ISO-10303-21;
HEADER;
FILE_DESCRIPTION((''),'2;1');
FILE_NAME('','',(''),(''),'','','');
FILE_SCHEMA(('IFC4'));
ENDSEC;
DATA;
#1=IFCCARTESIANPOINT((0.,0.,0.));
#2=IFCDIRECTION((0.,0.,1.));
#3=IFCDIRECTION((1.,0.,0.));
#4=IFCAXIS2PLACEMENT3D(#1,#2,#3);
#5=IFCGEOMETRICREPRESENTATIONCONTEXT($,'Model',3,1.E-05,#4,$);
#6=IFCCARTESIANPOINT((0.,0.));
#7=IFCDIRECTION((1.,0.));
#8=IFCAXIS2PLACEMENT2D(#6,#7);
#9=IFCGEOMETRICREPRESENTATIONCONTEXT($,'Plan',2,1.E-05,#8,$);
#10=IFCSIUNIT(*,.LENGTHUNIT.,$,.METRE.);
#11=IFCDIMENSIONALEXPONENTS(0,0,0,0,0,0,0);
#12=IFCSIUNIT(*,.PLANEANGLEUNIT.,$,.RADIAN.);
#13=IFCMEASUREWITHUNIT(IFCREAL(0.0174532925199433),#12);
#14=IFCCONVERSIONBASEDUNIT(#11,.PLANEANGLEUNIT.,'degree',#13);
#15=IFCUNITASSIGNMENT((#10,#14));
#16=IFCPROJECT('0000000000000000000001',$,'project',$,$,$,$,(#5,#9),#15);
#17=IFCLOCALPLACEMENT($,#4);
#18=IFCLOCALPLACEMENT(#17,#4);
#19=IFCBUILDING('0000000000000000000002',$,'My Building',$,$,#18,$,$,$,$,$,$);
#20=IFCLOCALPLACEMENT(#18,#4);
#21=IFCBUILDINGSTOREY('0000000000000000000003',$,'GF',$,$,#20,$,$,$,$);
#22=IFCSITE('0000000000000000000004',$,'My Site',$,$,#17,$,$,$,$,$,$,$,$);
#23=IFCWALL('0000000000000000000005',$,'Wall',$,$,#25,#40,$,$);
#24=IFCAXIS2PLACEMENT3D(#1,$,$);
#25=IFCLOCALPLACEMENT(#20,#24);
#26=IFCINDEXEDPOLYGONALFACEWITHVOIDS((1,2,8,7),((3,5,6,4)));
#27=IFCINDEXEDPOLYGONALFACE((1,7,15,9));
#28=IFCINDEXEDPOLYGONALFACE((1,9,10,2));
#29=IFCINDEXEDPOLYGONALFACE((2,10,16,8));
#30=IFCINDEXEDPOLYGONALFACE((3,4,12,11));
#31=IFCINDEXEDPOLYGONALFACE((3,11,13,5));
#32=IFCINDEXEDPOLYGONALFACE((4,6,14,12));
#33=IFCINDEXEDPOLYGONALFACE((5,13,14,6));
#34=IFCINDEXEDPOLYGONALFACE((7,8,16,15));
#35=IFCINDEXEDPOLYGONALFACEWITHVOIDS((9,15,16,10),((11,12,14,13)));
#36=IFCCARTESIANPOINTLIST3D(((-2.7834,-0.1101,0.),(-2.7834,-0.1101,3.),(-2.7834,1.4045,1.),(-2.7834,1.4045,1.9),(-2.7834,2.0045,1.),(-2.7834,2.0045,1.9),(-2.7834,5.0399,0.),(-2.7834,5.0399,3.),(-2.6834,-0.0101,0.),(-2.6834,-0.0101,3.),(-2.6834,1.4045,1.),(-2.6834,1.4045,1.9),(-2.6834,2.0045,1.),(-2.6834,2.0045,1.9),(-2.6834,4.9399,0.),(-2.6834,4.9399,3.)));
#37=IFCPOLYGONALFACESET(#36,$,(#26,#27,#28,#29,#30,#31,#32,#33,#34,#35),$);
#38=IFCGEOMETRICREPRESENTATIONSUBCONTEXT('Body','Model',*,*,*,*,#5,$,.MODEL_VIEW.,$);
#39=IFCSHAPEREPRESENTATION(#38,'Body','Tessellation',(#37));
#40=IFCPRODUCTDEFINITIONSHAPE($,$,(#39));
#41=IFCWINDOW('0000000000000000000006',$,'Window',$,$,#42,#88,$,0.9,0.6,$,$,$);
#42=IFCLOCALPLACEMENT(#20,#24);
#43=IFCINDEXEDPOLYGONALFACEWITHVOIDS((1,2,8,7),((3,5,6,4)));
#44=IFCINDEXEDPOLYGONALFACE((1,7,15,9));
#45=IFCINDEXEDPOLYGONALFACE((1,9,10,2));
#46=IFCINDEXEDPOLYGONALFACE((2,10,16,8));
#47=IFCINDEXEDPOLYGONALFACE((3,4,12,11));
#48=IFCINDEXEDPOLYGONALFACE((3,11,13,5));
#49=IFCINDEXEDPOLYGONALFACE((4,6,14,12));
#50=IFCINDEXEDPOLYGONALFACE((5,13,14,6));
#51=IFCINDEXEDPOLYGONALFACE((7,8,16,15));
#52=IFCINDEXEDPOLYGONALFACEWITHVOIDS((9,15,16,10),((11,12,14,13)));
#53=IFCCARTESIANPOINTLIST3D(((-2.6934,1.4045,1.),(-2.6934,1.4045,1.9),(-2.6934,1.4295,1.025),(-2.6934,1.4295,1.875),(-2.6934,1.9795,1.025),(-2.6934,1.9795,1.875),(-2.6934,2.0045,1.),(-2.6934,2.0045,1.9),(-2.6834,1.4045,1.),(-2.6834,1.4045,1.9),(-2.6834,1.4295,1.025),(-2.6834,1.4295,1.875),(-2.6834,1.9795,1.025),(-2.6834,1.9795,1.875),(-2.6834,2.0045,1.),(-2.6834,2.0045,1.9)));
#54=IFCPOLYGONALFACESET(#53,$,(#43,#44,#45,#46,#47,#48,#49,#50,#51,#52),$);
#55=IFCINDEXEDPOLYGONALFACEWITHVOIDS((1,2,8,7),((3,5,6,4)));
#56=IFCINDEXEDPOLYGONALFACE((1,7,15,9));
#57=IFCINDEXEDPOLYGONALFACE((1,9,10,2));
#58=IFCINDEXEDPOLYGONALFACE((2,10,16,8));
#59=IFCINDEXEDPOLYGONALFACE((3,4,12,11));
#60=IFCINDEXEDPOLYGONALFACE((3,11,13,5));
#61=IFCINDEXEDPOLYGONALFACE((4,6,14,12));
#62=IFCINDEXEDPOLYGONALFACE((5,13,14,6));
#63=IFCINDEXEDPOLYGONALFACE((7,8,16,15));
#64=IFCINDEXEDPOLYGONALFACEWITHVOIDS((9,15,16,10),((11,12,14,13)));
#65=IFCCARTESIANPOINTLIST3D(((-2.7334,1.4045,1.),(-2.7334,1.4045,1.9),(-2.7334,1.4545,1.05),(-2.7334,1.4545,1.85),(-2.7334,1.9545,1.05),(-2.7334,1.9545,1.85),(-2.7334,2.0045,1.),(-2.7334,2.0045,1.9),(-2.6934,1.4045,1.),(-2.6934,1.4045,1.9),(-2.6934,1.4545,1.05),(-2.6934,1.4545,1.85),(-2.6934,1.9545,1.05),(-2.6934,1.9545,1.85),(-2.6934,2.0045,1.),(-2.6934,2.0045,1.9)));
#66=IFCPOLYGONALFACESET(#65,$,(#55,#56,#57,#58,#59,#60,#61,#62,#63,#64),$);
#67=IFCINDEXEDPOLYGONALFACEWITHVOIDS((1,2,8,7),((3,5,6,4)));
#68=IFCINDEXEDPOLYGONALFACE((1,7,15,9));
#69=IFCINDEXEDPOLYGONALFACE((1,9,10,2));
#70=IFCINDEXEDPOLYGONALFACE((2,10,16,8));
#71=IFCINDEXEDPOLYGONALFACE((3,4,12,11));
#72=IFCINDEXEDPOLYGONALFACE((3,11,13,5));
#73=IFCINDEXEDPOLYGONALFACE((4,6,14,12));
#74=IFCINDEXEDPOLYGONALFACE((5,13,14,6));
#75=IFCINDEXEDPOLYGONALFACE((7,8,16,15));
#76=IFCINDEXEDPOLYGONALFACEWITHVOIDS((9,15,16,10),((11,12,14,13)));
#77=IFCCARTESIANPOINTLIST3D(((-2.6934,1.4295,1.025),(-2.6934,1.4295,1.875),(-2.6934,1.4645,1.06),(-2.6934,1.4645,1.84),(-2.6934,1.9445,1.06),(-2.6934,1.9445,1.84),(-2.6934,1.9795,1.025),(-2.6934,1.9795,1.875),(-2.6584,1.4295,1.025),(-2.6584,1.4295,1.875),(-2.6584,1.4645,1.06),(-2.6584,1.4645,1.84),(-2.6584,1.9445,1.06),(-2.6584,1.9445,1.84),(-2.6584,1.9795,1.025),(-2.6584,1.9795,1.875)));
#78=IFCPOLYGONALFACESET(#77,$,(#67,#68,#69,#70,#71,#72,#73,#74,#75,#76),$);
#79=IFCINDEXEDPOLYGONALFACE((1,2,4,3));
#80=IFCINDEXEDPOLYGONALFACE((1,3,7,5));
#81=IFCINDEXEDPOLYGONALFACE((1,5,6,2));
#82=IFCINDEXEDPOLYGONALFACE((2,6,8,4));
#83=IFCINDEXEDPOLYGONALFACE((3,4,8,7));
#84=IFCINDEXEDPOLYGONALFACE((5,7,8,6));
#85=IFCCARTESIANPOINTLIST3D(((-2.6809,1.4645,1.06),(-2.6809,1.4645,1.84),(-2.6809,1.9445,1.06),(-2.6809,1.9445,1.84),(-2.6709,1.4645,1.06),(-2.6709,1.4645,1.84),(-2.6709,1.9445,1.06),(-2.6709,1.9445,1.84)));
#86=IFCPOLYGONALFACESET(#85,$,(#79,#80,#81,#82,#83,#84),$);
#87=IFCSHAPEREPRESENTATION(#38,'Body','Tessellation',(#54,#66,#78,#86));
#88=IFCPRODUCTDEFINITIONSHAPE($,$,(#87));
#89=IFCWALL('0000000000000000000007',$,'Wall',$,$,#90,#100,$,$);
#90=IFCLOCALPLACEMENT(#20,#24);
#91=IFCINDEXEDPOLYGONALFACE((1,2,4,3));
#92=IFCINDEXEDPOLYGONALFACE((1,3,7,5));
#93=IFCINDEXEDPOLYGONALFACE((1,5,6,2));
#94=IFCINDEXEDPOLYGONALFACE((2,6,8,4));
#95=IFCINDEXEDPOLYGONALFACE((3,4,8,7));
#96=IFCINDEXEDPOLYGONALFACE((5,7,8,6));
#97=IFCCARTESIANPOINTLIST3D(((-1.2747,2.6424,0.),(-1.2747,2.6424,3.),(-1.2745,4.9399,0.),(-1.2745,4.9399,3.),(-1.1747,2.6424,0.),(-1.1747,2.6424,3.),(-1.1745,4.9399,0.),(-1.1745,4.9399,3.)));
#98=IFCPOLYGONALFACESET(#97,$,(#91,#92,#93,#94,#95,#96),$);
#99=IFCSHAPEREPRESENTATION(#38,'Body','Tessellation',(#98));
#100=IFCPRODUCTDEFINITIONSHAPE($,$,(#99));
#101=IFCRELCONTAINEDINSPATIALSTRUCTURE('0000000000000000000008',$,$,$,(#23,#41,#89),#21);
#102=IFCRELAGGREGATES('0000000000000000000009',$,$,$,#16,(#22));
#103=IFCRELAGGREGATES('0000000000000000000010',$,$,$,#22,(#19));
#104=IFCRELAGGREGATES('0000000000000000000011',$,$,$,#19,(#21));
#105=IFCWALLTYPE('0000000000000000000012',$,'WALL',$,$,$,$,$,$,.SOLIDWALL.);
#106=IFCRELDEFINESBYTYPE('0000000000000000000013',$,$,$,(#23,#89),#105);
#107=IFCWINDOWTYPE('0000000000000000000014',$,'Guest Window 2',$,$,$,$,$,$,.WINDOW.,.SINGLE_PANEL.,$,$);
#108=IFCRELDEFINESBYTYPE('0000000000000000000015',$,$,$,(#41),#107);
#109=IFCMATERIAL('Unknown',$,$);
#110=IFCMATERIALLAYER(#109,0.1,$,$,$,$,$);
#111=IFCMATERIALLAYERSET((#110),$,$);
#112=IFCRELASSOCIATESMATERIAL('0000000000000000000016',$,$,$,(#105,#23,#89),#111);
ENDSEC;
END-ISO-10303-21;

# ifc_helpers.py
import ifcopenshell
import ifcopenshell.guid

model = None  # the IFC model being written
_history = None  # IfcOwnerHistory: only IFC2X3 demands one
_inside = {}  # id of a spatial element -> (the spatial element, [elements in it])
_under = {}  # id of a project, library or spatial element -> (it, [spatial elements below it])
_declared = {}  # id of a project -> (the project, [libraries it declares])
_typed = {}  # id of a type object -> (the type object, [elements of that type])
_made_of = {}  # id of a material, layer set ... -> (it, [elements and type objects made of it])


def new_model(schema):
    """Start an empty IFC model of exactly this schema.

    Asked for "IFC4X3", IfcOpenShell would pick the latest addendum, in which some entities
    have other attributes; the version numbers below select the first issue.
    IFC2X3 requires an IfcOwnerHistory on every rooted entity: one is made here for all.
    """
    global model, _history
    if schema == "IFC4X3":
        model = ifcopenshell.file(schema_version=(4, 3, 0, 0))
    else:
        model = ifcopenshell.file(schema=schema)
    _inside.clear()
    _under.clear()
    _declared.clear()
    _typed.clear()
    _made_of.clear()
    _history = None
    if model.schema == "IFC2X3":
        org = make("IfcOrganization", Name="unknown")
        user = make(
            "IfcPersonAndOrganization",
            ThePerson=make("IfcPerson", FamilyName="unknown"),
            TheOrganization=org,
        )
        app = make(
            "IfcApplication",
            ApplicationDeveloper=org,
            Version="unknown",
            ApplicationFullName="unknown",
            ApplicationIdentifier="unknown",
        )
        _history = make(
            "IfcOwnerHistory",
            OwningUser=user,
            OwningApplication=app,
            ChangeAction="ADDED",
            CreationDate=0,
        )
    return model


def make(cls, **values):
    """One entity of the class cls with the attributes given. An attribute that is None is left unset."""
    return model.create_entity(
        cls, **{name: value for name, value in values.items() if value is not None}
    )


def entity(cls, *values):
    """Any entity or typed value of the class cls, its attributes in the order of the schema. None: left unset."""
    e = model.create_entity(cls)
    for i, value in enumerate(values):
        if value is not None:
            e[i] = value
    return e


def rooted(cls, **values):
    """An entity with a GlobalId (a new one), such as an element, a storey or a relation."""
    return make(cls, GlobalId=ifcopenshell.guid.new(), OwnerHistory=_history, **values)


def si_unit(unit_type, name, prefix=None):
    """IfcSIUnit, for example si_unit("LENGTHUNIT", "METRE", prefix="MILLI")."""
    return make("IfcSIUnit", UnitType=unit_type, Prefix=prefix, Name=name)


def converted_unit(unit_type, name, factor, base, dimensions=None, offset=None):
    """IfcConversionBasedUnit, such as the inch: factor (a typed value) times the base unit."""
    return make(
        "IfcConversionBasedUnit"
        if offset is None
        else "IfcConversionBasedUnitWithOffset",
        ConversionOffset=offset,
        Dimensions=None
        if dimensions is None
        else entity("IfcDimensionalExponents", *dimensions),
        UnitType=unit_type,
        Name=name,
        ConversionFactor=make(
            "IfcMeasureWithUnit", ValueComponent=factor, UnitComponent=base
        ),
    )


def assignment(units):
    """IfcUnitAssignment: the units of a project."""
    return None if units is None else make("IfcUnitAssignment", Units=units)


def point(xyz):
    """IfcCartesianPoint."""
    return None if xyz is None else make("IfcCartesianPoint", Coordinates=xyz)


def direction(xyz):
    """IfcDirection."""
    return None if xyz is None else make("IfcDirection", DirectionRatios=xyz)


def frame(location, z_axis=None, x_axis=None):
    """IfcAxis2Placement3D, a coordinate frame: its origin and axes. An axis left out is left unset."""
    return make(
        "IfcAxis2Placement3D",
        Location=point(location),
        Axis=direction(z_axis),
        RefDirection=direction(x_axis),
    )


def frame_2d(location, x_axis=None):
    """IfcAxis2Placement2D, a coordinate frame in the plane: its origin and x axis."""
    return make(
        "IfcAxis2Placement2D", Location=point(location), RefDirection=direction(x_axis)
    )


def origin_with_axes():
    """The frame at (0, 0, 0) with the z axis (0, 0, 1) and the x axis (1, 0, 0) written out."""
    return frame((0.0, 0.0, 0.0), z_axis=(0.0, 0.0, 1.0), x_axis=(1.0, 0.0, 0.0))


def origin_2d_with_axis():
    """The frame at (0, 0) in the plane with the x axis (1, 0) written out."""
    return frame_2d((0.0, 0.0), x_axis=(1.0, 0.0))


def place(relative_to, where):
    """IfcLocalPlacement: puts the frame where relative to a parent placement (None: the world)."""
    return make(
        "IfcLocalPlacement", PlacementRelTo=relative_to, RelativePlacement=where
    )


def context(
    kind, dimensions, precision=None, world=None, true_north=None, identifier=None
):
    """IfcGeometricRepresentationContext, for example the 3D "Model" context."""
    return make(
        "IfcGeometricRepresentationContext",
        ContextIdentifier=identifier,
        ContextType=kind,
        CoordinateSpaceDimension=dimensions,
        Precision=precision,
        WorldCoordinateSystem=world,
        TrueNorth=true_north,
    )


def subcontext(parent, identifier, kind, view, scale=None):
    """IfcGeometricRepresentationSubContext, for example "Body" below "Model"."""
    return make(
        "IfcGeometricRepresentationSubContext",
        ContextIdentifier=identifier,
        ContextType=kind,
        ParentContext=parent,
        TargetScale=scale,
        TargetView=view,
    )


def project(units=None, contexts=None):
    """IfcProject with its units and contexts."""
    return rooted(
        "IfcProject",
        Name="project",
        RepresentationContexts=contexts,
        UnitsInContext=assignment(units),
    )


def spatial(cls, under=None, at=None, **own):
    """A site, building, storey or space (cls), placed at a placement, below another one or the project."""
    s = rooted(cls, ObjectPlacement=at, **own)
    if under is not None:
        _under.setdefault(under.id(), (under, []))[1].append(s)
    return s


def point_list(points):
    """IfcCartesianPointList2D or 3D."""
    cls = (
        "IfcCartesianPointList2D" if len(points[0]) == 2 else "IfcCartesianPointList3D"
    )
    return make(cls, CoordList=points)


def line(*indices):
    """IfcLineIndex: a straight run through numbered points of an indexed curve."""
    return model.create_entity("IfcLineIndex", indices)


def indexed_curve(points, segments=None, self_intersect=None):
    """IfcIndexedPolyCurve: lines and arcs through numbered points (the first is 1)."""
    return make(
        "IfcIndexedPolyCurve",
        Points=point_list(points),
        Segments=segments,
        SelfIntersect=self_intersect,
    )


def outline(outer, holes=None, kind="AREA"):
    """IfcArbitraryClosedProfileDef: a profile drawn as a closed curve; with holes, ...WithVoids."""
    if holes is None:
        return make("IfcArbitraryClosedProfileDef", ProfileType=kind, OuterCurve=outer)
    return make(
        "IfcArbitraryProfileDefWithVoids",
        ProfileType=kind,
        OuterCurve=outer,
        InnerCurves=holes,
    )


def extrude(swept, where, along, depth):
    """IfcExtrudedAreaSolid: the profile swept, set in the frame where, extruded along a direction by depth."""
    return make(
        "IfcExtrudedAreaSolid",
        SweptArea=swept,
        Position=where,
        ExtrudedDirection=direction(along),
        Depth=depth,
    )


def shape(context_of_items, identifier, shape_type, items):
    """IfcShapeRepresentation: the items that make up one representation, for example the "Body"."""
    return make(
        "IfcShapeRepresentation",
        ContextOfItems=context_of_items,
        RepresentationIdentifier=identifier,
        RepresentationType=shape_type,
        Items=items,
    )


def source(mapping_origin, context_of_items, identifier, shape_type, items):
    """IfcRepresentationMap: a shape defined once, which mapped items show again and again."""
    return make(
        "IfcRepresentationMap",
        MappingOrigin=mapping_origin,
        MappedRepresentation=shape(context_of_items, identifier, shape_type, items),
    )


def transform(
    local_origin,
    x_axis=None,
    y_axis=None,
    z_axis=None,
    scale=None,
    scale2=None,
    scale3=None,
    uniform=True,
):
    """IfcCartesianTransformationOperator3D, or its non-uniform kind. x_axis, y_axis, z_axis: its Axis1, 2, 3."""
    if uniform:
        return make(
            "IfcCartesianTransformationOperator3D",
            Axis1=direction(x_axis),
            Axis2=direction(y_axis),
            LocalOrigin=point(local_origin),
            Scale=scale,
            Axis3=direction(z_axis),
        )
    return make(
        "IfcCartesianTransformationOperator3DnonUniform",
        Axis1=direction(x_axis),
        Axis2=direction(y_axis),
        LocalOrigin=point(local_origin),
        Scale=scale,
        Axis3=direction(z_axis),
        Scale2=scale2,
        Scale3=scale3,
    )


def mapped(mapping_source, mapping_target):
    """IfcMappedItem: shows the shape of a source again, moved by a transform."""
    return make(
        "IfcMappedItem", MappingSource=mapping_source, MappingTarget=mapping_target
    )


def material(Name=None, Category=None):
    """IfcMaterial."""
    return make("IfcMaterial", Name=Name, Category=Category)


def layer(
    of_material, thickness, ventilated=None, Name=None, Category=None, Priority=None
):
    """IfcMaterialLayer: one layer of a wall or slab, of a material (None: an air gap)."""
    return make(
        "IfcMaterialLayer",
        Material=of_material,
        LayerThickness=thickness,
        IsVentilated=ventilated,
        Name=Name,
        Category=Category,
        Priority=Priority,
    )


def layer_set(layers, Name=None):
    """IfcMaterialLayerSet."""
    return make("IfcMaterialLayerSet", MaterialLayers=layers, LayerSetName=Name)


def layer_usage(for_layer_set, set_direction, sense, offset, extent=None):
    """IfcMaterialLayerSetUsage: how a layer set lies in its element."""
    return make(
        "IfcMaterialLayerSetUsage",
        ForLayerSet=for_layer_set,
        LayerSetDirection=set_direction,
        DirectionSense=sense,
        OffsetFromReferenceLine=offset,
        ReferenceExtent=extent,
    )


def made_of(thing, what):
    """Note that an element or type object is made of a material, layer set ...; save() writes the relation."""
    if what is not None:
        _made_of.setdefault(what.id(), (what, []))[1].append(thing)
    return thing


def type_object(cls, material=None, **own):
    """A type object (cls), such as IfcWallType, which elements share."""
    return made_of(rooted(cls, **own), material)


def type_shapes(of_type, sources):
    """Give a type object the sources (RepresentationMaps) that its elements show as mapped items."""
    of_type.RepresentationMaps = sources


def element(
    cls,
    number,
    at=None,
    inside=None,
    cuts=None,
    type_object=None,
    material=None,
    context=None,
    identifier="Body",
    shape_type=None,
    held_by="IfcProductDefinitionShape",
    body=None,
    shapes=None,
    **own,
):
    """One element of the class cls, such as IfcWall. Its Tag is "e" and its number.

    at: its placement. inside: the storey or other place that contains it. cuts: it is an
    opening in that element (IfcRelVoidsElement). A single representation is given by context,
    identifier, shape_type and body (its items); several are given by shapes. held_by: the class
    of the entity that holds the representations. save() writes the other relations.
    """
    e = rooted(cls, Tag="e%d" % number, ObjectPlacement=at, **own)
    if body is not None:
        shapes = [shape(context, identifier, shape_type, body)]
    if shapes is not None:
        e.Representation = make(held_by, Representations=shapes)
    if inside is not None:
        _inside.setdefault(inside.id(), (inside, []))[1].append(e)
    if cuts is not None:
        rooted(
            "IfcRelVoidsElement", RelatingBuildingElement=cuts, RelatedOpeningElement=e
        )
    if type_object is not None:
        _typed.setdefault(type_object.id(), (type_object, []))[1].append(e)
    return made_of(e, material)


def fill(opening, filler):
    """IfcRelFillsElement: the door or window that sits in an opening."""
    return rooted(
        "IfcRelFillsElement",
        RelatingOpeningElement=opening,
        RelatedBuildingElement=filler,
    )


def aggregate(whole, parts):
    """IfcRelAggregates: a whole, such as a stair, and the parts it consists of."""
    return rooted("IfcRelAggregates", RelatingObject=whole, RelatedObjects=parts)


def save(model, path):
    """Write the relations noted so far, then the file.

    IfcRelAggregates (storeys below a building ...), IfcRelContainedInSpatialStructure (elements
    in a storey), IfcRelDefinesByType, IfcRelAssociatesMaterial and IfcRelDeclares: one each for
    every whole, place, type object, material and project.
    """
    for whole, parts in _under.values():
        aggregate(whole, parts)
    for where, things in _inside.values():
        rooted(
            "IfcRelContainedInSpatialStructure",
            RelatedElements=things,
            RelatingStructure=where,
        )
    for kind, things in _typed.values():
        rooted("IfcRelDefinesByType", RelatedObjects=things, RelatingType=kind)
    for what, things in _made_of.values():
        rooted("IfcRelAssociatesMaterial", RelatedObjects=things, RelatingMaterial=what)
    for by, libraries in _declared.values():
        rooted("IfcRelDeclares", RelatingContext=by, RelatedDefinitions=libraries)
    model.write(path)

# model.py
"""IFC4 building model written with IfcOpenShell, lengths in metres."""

from ifc_helpers import new_model, entity, si_unit, converted_unit, frame, origin_with_axes, origin_2d_with_axis, place, context, subcontext, project, spatial, line, indexed_curve, outline, extrude, shape, source, transform, mapped, material, layer, layer_set, layer_usage, type_object, type_shapes, element, fill, save


model = new_model("IFC4")

# Units and contexts
model_context = context("Model", 3, precision=1e-05, world=origin_with_axes())
plan_context = context("Plan", 2, precision=1e-05, world=origin_2d_with_axis())
body_context_1 = subcontext(model_context, "Body", "Model", "MODEL_VIEW")
body_context_2 = subcontext(plan_context, "Body", "Plan", "PLAN_VIEW")
ifc_project = project(units=[si_unit("LENGTHUNIT", "METRE"), converted_unit("PLANEANGLEUNIT", "degree", entity("IfcReal", 0.0174532925199433), si_unit("PLANEANGLEUNIT", "RADIAN"), dimensions=[0, 0, 0, 0, 0, 0, 0])], contexts=[model_context, plan_context])

# Site, building, storey
site_placement = place(None, origin_with_axes())
site = spatial("IfcSite", under=ifc_project, at=site_placement, Name="My Site")
building_placement = place(site_placement, origin_with_axes())
building = spatial("IfcBuilding", under=site, at=building_placement, Name="My Building")
storey_placement = place(building_placement, origin_with_axes())
storey = spatial("IfcBuildingStorey", under=building, at=storey_placement, Name="GF")

# Shared definitions
ifc_material = material(Name="Unknown")

# Shared definitions
ifc_layer = layer(ifc_material, 0.1)
ifc_layer_set = layer_set([ifc_layer])
wall_type = type_object("IfcWallType", Name="WALL", PredefinedType="SOLIDWALL", material=ifc_layer_set)

# Wall, opening, window
ifc_layer_usage_1 = layer_usage(ifc_layer_set, "AXIS2", "POSITIVE", 0.0)
wall_1_placement = place(storey_placement, frame((-2.7834, 5.0399, 0.0), z_axis=(0.0, 0.0, 1.0), x_axis=(0.0, -1.0, 0.0)))
wall_1 = element("IfcWall", 1, at=wall_1_placement, inside=storey, type_object=wall_type, material=ifc_layer_usage_1, Name="Wall", context=body_context_1, shape_type="SweptSolid", body=[
    extrude(outline(indexed_curve([(0.0, 0.0), (0.1, 0.1), (5.05, 0.1), (5.15, 0.0)], segments=[line(1, 2, 3, 4, 1)])), origin_with_axes(), (0.0, 0.0, 1.0), 3.0),
])
shared_shape_1 = source(origin_with_axes(), body_context_1, "Body", "SweptSolid", [
    extrude(outline(indexed_curve([(0.0, 0.0), (0.6, 0.0), (0.6, 0.9), (0.0, 0.9)], segments=[line(1, 2, 3, 4, 1)])), frame((0.0, -0.6, 0.0), z_axis=(0.0, -1.0, 0.0), x_axis=(1.0, 0.0, 0.0)), (0.0, 0.0, -1.0), 1.2),
])
opening_1_placement = place(wall_1_placement, frame((3.0354, 0.0, 1.0), z_axis=(0.0, 0.0, 1.0), x_axis=(1.0, 0.0, 0.0)))
opening_1 = element("IfcOpeningElement", 2, at=opening_1_placement, cuts=wall_1, PredefinedType="OPENING", context=body_context_1, shape_type="MappedRepresentation", body=[
    mapped(shared_shape_1, transform((0.0, 0.0, 0.0), x_axis=(1.0, 0.0, 0.0), y_axis=(0.0, 1.0, 0.0), z_axis=(0.0, 0.0, 1.0), scale=1.0)),
])
window_type_1 = type_object("IfcWindowType", Name="Guest Window 2", PartitioningType="SINGLE_PANEL", PredefinedType="WINDOW")
shared_shape_2 = source(origin_with_axes(), body_context_1, "Body", "SweptSolid", [
    extrude(outline(indexed_curve([(0.0, 0.0), (0.6, 0.0), (0.6, 0.9), (0.0, 0.9)], segments=[line(1, 2, 3, 4, 1)]), holes=[indexed_curve([(0.025, 0.025), (0.575, 0.025), (0.575, 0.875), (0.025, 0.875)], segments=[line(1, 2, 3, 4, 1)])]), frame((0.0, 0.09, 0.0), z_axis=(0.0, -1.0, 0.0), x_axis=(1.0, 0.0, 0.0)), (0.0, 0.0, -1.0), 0.01),
    extrude(outline(indexed_curve([(0.0, 0.0), (0.6, 0.0), (0.6, 0.9), (0.0, 0.9)], segments=[line(1, 2, 3, 4, 1)]), holes=[indexed_curve([(0.05, 0.05), (0.55, 0.05), (0.55, 0.85), (0.05, 0.85)], segments=[line(1, 2, 3, 4, 1)])]), frame((0.0, 0.05, 0.0), z_axis=(0.0, -1.0, 0.0), x_axis=(1.0, 0.0, 0.0)), (0.0, 0.0, -1.0), 0.04),
    extrude(outline(indexed_curve([(0.0, 0.0), (0.55, 0.0), (0.55, 0.85), (0.0, 0.85)], segments=[line(1, 2, 3, 4, 1)]), holes=[indexed_curve([(0.035, 0.035), (0.515, 0.035), (0.515, 0.815), (0.035, 0.815)], segments=[line(1, 2, 3, 4, 1)])]), frame((0.025, 0.09, 0.025), z_axis=(0.0, -1.0, 0.0), x_axis=(1.0, 0.0, 0.0)), (0.0, 0.0, -1.0), 0.035),
    extrude(outline(indexed_curve([(0.035, 0.035), (0.515, 0.035), (0.515, 0.815), (0.035, 0.815)], segments=[line(1, 2, 3, 4, 1)])), frame((0.025, 0.1025, 0.025), z_axis=(0.0, -1.0, 0.0), x_axis=(1.0, 0.0, 0.0)), (0.0, 0.0, -1.0), 0.01),
])
shared_shape_3 = source(origin_with_axes(), body_context_2, "Body", "Curve2D", [
    entity("IfcIndexedPolyCurve", entity("IfcCartesianPointList2D", [[0.05, 0.05], [0.55, 0.05]])),
    entity("IfcIndexedPolyCurve", entity("IfcCartesianPointList2D", [[0.0, 0.1], [0.025, 0.1], [0.025, 0.09], [0.05, 0.09], [0.05, 0.05], [0.0, 0.05]]), [entity("IfcLineIndex", [1, 2, 3, 4, 5, 6, 1])]),
    entity("IfcIndexedPolyCurve", entity("IfcCartesianPointList2D", [[0.6, 0.1], [0.575, 0.1], [0.575, 0.09], [0.55, 0.09], [0.55, 0.05], [0.6, 0.05]]), [entity("IfcLineIndex", [1, 2, 3, 4, 5, 6, 1])]),
    entity("IfcIndexedPolyCurve", entity("IfcCartesianPointList2D", [[0.025, 0.09], [0.06, 0.09], [0.06, 0.125], [0.025, 0.125]]), [entity("IfcLineIndex", [1, 2, 3, 4, 1])]),
    entity("IfcIndexedPolyCurve", entity("IfcCartesianPointList2D", [[0.575, 0.09], [0.54, 0.09], [0.54, 0.125], [0.575, 0.125]]), [entity("IfcLineIndex", [1, 2, 3, 4, 1])]),
    entity("IfcIndexedPolyCurve", entity("IfcCartesianPointList2D", [[0.06, 0.09], [0.54, 0.09]])),
    entity("IfcIndexedPolyCurve", entity("IfcCartesianPointList2D", [[0.06, 0.125], [0.54, 0.125]])),
    entity("IfcIndexedPolyCurve", entity("IfcCartesianPointList2D", [[0.06, 0.1075], [0.54, 0.1075]])),
])
type_shapes(window_type_1, [shared_shape_2, shared_shape_3])
window_1_placement = place(opening_1_placement, frame((0.0, 0.0, 0.0), z_axis=(0.0, 0.0, 1.0), x_axis=(1.0, 0.0, 0.0)))
window_1 = element("IfcWindow", 3, at=window_1_placement, inside=storey, type_object=window_type_1, Name="Window", OverallHeight=0.9, OverallWidth=0.6, shapes=[
    shape(body_context_1, "Body", "MappedRepresentation", [mapped(shared_shape_2, transform((0.0, 0.0, 0.0), x_axis=(1.0, 0.0, 0.0), y_axis=(0.0, 1.0, 0.0), z_axis=(0.0, 0.0, 1.0), scale=1.0))]),
    shape(body_context_2, "Body", "MappedRepresentation", [mapped(shared_shape_3, transform((0.0, 0.0, 0.0), x_axis=(1.0, 0.0, 0.0), y_axis=(0.0, 1.0, 0.0), z_axis=(0.0, 0.0, 1.0), scale=1.0))]),
])
fill(opening_1, window_1)

# Wall
ifc_layer_usage_2 = layer_usage(ifc_layer_set, "AXIS2", "POSITIVE", 0.0)
wall_2_placement = place(storey_placement, frame((-1.2745, 4.9399, 0.0), z_axis=(0.0, 0.0, 1.0), x_axis=(-0.000123, -1.0, 0.0)))
element("IfcWall", 4, at=wall_2_placement, inside=storey, type_object=wall_type, material=ifc_layer_usage_2, Name="Wall", context=body_context_1, shape_type="SweptSolid", body=[
    extrude(outline(indexed_curve([(0.0, 0.0), (0.0, 0.1), (2.2975, 0.1), (2.2975, 0.0)], segments=[line(1, 2, 3, 4, 1)])), origin_with_axes(), (0.0, 0.0, 1.0), 3.0),
])

save(model, "model.ifc")
